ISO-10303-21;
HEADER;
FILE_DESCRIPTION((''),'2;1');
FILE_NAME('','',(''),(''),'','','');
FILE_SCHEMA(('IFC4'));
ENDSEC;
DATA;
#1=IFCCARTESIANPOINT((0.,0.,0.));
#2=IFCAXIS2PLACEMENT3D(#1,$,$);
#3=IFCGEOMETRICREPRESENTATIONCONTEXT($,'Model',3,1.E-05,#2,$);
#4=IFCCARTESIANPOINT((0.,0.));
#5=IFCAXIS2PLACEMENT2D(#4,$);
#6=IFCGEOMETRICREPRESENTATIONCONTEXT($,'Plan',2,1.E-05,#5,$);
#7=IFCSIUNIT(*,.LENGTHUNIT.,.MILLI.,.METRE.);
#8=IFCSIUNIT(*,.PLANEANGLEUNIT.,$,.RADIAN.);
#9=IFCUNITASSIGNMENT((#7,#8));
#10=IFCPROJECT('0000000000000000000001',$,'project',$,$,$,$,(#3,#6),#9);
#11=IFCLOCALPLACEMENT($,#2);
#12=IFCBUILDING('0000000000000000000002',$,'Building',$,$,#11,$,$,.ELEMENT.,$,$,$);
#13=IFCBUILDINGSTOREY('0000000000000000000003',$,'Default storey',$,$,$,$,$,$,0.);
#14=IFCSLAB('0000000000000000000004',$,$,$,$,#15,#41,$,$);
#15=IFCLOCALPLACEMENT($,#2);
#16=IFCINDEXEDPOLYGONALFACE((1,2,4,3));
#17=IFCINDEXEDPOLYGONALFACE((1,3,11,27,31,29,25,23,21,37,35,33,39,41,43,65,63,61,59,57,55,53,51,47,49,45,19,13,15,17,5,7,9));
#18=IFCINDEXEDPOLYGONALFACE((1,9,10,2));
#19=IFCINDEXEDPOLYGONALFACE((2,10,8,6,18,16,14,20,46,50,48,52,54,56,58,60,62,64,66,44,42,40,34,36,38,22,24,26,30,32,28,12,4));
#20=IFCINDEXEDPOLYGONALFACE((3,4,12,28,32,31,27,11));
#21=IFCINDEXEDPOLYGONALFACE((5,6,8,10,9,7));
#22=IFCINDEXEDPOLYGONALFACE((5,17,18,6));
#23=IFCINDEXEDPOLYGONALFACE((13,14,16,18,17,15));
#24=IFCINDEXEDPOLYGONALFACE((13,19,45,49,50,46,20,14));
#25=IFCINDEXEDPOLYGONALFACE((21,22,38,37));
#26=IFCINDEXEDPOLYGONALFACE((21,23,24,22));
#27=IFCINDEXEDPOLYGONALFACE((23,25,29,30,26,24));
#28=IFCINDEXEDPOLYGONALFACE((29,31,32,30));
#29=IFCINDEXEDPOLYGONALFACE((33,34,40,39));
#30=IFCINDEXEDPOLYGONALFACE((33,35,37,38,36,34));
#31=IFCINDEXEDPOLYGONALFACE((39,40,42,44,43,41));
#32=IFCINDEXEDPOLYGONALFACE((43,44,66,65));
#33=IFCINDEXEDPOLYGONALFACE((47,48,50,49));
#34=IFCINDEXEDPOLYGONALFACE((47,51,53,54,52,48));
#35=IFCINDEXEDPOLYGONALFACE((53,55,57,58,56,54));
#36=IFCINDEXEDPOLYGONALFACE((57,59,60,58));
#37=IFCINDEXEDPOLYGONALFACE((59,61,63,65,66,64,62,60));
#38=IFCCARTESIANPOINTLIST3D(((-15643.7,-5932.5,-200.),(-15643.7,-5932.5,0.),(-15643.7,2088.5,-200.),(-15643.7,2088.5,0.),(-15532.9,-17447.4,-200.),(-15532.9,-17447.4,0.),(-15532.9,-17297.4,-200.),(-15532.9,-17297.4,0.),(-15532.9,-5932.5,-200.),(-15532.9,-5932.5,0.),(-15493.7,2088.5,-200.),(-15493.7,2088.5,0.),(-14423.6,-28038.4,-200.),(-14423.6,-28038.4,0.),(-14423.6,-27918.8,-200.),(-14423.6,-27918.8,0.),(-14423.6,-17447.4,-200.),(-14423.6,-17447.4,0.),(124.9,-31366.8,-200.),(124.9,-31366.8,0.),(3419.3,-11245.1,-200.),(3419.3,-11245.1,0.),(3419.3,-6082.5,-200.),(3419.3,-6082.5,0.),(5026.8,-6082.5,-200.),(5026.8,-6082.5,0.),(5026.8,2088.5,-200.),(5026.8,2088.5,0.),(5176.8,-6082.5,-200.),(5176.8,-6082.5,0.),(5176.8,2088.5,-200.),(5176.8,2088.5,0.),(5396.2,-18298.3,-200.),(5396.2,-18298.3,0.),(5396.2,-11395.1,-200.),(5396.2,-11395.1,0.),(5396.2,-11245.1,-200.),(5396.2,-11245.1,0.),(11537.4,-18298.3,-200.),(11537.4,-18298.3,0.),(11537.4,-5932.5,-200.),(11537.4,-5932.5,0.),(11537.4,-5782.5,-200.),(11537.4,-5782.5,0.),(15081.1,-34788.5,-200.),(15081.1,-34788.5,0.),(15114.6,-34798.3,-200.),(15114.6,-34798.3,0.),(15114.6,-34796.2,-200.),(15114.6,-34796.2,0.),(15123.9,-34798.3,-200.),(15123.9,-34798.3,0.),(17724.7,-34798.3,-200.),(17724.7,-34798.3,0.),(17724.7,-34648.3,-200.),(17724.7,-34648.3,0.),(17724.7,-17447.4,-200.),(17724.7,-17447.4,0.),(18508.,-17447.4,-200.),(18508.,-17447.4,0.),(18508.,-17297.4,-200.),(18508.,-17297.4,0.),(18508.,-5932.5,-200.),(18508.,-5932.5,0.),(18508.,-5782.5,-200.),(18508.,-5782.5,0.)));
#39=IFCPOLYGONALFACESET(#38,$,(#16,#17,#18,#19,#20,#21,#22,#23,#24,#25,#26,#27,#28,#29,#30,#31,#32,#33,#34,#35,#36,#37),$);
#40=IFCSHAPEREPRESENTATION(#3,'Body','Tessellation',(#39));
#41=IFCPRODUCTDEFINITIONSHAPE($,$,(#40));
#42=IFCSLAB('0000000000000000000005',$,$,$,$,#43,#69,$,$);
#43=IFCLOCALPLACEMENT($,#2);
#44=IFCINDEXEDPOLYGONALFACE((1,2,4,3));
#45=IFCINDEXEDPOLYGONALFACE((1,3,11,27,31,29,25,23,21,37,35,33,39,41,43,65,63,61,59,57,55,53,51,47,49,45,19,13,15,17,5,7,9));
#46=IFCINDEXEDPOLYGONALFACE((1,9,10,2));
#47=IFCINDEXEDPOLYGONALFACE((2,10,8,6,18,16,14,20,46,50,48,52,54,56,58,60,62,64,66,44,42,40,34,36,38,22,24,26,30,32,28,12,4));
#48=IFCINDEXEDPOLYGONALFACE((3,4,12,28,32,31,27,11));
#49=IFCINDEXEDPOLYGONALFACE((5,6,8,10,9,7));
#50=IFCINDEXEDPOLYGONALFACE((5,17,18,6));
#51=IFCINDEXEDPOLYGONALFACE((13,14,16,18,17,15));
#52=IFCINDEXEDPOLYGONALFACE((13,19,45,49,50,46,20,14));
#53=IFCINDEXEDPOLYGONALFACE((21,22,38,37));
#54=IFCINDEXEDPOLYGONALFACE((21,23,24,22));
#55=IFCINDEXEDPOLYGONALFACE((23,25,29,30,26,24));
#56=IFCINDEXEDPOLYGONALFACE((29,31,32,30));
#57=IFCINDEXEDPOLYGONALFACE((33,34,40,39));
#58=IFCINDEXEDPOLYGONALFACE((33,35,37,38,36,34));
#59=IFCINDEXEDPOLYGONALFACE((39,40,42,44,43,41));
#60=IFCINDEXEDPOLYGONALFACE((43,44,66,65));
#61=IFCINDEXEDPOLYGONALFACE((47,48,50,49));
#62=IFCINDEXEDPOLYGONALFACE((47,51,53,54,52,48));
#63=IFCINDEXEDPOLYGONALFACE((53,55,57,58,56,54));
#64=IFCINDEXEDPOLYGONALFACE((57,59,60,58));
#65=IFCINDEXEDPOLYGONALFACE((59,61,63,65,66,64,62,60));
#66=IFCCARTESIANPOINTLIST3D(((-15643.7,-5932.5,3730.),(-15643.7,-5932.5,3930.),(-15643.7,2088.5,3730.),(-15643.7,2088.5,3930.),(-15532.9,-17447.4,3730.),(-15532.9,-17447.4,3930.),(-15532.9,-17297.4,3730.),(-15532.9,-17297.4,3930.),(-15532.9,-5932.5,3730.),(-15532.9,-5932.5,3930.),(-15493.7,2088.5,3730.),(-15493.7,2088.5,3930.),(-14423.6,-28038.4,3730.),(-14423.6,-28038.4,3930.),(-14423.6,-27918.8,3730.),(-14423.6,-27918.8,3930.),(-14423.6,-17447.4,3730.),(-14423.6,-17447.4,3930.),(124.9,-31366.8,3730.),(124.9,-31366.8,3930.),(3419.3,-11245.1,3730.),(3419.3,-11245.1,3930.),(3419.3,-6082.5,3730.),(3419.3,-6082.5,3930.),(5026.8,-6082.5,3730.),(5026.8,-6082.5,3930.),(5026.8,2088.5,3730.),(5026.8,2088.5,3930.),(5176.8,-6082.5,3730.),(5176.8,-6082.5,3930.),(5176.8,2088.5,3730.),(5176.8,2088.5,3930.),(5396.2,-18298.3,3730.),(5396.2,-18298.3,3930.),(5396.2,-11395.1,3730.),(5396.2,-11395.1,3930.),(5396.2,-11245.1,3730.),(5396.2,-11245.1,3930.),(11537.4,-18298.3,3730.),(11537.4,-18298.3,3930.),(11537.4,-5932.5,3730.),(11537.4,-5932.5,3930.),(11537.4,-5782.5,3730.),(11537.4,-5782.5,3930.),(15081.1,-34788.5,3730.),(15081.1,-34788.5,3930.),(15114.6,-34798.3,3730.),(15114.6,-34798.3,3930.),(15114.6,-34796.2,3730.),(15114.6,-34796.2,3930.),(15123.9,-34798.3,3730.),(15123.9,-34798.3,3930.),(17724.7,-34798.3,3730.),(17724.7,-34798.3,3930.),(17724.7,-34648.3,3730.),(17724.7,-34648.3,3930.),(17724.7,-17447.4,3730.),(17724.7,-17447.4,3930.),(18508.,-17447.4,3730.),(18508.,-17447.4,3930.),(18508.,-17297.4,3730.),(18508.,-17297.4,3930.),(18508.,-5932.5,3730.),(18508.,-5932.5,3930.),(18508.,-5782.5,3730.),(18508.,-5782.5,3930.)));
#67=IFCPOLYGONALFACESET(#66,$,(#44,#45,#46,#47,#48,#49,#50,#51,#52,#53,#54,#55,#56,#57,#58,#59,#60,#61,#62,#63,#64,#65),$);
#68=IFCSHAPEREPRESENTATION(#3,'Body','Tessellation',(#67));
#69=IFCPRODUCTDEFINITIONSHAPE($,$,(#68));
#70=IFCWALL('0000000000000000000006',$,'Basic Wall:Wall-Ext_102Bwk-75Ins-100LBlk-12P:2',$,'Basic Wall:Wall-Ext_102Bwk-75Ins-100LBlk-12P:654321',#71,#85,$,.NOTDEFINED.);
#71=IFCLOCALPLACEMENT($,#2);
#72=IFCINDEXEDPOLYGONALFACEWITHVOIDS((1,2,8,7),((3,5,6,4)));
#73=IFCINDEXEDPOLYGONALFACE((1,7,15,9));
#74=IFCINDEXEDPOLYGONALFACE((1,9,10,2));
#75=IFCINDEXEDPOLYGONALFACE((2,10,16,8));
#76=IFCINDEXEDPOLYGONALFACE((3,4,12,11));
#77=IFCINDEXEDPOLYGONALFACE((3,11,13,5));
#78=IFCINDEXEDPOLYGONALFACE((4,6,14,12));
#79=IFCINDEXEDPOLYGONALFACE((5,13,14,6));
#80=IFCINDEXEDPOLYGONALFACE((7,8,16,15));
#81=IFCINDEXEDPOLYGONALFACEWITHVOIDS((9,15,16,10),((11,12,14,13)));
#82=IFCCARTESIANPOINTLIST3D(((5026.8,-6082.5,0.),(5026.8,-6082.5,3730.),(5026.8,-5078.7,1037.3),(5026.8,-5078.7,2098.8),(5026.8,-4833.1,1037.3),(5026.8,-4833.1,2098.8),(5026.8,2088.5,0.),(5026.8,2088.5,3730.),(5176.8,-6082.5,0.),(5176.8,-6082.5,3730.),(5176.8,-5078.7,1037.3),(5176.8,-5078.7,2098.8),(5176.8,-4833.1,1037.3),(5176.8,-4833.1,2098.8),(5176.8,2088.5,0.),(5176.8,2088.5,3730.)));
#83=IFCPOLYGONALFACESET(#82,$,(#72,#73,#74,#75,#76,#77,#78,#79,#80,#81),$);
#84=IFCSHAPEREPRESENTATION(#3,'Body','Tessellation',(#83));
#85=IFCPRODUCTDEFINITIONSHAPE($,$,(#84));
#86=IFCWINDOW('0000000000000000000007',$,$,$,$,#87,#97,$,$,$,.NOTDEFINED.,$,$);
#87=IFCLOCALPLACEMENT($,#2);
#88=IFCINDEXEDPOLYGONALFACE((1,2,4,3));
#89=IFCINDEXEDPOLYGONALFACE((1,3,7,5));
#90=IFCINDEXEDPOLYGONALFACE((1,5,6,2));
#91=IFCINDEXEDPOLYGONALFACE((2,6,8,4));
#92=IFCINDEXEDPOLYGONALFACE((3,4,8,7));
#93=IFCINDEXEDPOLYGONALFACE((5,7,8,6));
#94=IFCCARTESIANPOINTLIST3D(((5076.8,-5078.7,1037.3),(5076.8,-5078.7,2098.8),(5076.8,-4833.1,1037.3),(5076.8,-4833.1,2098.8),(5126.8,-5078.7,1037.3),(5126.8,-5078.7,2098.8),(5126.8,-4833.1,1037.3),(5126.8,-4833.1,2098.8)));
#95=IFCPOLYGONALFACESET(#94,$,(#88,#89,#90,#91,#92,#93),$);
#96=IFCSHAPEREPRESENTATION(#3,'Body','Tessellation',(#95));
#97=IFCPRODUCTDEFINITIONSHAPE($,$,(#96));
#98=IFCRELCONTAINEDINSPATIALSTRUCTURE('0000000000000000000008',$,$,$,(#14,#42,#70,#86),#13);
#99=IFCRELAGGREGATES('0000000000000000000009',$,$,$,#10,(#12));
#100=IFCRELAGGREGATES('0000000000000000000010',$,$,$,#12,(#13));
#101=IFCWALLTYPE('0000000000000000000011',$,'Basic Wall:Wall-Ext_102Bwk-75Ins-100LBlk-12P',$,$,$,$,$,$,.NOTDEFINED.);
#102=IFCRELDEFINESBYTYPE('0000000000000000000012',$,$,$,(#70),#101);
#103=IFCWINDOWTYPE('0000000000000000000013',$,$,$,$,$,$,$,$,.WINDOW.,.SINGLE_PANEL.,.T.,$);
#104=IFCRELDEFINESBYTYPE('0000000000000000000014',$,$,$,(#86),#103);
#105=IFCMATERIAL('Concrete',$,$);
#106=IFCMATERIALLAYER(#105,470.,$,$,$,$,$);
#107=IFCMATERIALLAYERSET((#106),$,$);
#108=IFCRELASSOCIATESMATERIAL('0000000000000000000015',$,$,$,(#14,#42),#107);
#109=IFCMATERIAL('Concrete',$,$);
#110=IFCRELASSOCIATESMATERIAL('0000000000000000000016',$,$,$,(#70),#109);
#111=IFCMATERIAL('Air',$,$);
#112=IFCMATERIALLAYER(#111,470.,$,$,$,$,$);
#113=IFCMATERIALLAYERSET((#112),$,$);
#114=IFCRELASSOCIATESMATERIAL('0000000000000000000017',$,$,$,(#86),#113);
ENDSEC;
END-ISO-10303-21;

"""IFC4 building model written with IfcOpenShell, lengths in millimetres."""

from ifc_helpers import new_model, si_unit, frame, origin, origin_2d, place, context, project, spatial, polyline, rectangle, outline, extrude, boolean, material, layer, layer_set, layer_usage, type_object, element, save


model = new_model("IFC4")

# Units and contexts
model_context = context("Model", 3, precision=1e-05, world=origin())
plan_context = context("Plan", 2, precision=1e-05, world=origin_2d())
ifc_project = project(units=[si_unit("LENGTHUNIT", "METRE", prefix="MILLI"), si_unit("PLANEANGLEUNIT", "RADIAN")], contexts=[model_context, plan_context])

# Building, storey
placement = place(None, origin())
building = spatial("IfcBuilding", under=ifc_project, at=placement, Name="Building", CompositionType="ELEMENT")
storey = spatial("IfcBuildingStorey", under=building, Name="Default storey", Elevation=0.0)

# Slabs
ifc_material_1 = material(Name="Concrete")
ifc_layer_1 = layer(ifc_material_1, 470.0)
ifc_layer_set_1 = layer_set([ifc_layer_1])
ifc_layer_usage_1 = layer_usage(ifc_layer_set_1, "AXIS3", "POSITIVE", 0.0)
element("IfcSlab", 1, at=placement, inside=storey, material=ifc_layer_usage_1, context=model_context, shape_type="SweptSolid", body=[
    extrude(outline(polyline([(15114.6, -34798.3), (15123.9, -34798.3), (17724.7, -34798.3), (17724.7, -34648.3), (17724.7, -17447.4), (18508.0, -17447.4), (18508.0, -17297.4), (18508.0, -5932.5), (18508.0, -5782.5), (11537.4, -5782.5), (11537.4, -5932.5), (11537.4, -18298.3), (5396.2, -18298.3), (5396.2, -11395.1), (5396.2, -11245.1), (3419.3, -11245.1), (3419.3, -6082.5), (5026.8, -6082.5), (5176.8, -6082.5), (5176.8, 2088.5), (5026.8, 2088.5), (-15493.7, 2088.5), (-15643.7, 2088.5), (-15643.7, -5932.5), (-15532.9, -5932.5), (-15532.9, -17297.4), (-15532.9, -17447.4), (-14423.6, -17447.4), (-14423.6, -27918.8), (-14423.6, -28038.4), (124.9, -31366.8), (15081.1, -34788.5), (15081.1, -34788.5), (15114.6, -34796.2), (15114.6, -34798.3)])), frame((0.0, 0.0, -200.0), z_axis=(0.0, 0.0, 1000.0), x_axis=(1000.0, 0.0, 0.0)), (0.0, 0.0, 1.0), 200.0),
])
element("IfcSlab", 2, at=placement, inside=storey, material=ifc_layer_usage_1, context=model_context, shape_type="SweptSolid", body=[
    extrude(outline(polyline([(15114.6, -34798.3), (15123.9, -34798.3), (17724.7, -34798.3), (17724.7, -34648.3), (17724.7, -17447.4), (18508.0, -17447.4), (18508.0, -17297.4), (18508.0, -5932.5), (18508.0, -5782.5), (11537.4, -5782.5), (11537.4, -5932.5), (11537.4, -18298.3), (5396.2, -18298.3), (5396.2, -11395.1), (5396.2, -11245.1), (3419.3, -11245.1), (3419.3, -6082.5), (5026.8, -6082.5), (5176.8, -6082.5), (5176.8, 2088.5), (5026.8, 2088.5), (-15493.7, 2088.5), (-15643.7, 2088.5), (-15643.7, -5932.5), (-15532.9, -5932.5), (-15532.9, -17297.4), (-15532.9, -17447.4), (-14423.6, -17447.4), (-14423.6, -27918.8), (-14423.6, -28038.4), (124.9, -31366.8), (15081.1, -34788.5), (15081.1, -34788.5), (15114.6, -34796.2), (15114.6, -34798.3)])), frame((0.0, 0.0, 3930.0), z_axis=(0.0, 0.0, 1000.0), x_axis=(1000.0, 0.0, 0.0)), (0.0, 0.0, -1.0), 200.0),
])

# Wall
wall_type = type_object("IfcWallType", Name="Basic Wall:Wall-Ext_102Bwk-75Ins-100LBlk-12P", PredefinedType="NOTDEFINED")
ifc_material_2 = material(Name="Concrete")
element("IfcWall", 3, at=placement, inside=storey, type_object=wall_type, material=ifc_material_2, Name="Basic Wall:Wall-Ext_102Bwk-75Ins-100LBlk-12P:2", ObjectType="Basic Wall:Wall-Ext_102Bwk-75Ins-100LBlk-12P:654321", PredefinedType="NOTDEFINED", context=model_context, shape_type="CSG", body=[
    boolean("DIFFERENCE", extrude(rectangle(XDim=8171.0, YDim=150.0, at=origin_2d()), frame((5101.8, -1997.0, 0.0), z_axis=(0.0, 0.0, 1.0), x_axis=(0.0, 8171.049893, 0.0)), (0.0, 0.0, 1.0), 3730.0), extrude(rectangle(XDim=245.6, YDim=150.0, at=origin_2d()), frame((5101.8, -4955.9, 1037.3), z_axis=(0.0, 0.0, 1000.0), x_axis=(0.0, 245.59464, 0.0)), (0.0, 0.0, 1.0), 1061.5)),
])

# Window
ifc_material_3 = material(Name="Air")
ifc_layer_2 = layer(ifc_material_3, 470.0)
ifc_layer_set_2 = layer_set([ifc_layer_2])
ifc_layer_usage_2 = layer_usage(ifc_layer_set_2, "AXIS3", "POSITIVE", 0.0)
window_type = type_object("IfcWindowType", ParameterTakesPrecedence=True, PartitioningType="SINGLE_PANEL", PredefinedType="WINDOW")
element("IfcWindow", 4, at=placement, inside=storey, type_object=window_type, material=ifc_layer_usage_2, PredefinedType="NOTDEFINED", context=model_context, shape_type="CSG", body=[
    extrude(rectangle(XDim=245.6, YDim=50.0, at=origin_2d()), frame((5101.8, -4955.9, 1037.3), z_axis=(0.0, 0.0, 1000.0), x_axis=(0.0, 245.59464, 0.0)), (0.0, 0.0, 1.0), 1061.5),
])

save(model, "model.ifc")
